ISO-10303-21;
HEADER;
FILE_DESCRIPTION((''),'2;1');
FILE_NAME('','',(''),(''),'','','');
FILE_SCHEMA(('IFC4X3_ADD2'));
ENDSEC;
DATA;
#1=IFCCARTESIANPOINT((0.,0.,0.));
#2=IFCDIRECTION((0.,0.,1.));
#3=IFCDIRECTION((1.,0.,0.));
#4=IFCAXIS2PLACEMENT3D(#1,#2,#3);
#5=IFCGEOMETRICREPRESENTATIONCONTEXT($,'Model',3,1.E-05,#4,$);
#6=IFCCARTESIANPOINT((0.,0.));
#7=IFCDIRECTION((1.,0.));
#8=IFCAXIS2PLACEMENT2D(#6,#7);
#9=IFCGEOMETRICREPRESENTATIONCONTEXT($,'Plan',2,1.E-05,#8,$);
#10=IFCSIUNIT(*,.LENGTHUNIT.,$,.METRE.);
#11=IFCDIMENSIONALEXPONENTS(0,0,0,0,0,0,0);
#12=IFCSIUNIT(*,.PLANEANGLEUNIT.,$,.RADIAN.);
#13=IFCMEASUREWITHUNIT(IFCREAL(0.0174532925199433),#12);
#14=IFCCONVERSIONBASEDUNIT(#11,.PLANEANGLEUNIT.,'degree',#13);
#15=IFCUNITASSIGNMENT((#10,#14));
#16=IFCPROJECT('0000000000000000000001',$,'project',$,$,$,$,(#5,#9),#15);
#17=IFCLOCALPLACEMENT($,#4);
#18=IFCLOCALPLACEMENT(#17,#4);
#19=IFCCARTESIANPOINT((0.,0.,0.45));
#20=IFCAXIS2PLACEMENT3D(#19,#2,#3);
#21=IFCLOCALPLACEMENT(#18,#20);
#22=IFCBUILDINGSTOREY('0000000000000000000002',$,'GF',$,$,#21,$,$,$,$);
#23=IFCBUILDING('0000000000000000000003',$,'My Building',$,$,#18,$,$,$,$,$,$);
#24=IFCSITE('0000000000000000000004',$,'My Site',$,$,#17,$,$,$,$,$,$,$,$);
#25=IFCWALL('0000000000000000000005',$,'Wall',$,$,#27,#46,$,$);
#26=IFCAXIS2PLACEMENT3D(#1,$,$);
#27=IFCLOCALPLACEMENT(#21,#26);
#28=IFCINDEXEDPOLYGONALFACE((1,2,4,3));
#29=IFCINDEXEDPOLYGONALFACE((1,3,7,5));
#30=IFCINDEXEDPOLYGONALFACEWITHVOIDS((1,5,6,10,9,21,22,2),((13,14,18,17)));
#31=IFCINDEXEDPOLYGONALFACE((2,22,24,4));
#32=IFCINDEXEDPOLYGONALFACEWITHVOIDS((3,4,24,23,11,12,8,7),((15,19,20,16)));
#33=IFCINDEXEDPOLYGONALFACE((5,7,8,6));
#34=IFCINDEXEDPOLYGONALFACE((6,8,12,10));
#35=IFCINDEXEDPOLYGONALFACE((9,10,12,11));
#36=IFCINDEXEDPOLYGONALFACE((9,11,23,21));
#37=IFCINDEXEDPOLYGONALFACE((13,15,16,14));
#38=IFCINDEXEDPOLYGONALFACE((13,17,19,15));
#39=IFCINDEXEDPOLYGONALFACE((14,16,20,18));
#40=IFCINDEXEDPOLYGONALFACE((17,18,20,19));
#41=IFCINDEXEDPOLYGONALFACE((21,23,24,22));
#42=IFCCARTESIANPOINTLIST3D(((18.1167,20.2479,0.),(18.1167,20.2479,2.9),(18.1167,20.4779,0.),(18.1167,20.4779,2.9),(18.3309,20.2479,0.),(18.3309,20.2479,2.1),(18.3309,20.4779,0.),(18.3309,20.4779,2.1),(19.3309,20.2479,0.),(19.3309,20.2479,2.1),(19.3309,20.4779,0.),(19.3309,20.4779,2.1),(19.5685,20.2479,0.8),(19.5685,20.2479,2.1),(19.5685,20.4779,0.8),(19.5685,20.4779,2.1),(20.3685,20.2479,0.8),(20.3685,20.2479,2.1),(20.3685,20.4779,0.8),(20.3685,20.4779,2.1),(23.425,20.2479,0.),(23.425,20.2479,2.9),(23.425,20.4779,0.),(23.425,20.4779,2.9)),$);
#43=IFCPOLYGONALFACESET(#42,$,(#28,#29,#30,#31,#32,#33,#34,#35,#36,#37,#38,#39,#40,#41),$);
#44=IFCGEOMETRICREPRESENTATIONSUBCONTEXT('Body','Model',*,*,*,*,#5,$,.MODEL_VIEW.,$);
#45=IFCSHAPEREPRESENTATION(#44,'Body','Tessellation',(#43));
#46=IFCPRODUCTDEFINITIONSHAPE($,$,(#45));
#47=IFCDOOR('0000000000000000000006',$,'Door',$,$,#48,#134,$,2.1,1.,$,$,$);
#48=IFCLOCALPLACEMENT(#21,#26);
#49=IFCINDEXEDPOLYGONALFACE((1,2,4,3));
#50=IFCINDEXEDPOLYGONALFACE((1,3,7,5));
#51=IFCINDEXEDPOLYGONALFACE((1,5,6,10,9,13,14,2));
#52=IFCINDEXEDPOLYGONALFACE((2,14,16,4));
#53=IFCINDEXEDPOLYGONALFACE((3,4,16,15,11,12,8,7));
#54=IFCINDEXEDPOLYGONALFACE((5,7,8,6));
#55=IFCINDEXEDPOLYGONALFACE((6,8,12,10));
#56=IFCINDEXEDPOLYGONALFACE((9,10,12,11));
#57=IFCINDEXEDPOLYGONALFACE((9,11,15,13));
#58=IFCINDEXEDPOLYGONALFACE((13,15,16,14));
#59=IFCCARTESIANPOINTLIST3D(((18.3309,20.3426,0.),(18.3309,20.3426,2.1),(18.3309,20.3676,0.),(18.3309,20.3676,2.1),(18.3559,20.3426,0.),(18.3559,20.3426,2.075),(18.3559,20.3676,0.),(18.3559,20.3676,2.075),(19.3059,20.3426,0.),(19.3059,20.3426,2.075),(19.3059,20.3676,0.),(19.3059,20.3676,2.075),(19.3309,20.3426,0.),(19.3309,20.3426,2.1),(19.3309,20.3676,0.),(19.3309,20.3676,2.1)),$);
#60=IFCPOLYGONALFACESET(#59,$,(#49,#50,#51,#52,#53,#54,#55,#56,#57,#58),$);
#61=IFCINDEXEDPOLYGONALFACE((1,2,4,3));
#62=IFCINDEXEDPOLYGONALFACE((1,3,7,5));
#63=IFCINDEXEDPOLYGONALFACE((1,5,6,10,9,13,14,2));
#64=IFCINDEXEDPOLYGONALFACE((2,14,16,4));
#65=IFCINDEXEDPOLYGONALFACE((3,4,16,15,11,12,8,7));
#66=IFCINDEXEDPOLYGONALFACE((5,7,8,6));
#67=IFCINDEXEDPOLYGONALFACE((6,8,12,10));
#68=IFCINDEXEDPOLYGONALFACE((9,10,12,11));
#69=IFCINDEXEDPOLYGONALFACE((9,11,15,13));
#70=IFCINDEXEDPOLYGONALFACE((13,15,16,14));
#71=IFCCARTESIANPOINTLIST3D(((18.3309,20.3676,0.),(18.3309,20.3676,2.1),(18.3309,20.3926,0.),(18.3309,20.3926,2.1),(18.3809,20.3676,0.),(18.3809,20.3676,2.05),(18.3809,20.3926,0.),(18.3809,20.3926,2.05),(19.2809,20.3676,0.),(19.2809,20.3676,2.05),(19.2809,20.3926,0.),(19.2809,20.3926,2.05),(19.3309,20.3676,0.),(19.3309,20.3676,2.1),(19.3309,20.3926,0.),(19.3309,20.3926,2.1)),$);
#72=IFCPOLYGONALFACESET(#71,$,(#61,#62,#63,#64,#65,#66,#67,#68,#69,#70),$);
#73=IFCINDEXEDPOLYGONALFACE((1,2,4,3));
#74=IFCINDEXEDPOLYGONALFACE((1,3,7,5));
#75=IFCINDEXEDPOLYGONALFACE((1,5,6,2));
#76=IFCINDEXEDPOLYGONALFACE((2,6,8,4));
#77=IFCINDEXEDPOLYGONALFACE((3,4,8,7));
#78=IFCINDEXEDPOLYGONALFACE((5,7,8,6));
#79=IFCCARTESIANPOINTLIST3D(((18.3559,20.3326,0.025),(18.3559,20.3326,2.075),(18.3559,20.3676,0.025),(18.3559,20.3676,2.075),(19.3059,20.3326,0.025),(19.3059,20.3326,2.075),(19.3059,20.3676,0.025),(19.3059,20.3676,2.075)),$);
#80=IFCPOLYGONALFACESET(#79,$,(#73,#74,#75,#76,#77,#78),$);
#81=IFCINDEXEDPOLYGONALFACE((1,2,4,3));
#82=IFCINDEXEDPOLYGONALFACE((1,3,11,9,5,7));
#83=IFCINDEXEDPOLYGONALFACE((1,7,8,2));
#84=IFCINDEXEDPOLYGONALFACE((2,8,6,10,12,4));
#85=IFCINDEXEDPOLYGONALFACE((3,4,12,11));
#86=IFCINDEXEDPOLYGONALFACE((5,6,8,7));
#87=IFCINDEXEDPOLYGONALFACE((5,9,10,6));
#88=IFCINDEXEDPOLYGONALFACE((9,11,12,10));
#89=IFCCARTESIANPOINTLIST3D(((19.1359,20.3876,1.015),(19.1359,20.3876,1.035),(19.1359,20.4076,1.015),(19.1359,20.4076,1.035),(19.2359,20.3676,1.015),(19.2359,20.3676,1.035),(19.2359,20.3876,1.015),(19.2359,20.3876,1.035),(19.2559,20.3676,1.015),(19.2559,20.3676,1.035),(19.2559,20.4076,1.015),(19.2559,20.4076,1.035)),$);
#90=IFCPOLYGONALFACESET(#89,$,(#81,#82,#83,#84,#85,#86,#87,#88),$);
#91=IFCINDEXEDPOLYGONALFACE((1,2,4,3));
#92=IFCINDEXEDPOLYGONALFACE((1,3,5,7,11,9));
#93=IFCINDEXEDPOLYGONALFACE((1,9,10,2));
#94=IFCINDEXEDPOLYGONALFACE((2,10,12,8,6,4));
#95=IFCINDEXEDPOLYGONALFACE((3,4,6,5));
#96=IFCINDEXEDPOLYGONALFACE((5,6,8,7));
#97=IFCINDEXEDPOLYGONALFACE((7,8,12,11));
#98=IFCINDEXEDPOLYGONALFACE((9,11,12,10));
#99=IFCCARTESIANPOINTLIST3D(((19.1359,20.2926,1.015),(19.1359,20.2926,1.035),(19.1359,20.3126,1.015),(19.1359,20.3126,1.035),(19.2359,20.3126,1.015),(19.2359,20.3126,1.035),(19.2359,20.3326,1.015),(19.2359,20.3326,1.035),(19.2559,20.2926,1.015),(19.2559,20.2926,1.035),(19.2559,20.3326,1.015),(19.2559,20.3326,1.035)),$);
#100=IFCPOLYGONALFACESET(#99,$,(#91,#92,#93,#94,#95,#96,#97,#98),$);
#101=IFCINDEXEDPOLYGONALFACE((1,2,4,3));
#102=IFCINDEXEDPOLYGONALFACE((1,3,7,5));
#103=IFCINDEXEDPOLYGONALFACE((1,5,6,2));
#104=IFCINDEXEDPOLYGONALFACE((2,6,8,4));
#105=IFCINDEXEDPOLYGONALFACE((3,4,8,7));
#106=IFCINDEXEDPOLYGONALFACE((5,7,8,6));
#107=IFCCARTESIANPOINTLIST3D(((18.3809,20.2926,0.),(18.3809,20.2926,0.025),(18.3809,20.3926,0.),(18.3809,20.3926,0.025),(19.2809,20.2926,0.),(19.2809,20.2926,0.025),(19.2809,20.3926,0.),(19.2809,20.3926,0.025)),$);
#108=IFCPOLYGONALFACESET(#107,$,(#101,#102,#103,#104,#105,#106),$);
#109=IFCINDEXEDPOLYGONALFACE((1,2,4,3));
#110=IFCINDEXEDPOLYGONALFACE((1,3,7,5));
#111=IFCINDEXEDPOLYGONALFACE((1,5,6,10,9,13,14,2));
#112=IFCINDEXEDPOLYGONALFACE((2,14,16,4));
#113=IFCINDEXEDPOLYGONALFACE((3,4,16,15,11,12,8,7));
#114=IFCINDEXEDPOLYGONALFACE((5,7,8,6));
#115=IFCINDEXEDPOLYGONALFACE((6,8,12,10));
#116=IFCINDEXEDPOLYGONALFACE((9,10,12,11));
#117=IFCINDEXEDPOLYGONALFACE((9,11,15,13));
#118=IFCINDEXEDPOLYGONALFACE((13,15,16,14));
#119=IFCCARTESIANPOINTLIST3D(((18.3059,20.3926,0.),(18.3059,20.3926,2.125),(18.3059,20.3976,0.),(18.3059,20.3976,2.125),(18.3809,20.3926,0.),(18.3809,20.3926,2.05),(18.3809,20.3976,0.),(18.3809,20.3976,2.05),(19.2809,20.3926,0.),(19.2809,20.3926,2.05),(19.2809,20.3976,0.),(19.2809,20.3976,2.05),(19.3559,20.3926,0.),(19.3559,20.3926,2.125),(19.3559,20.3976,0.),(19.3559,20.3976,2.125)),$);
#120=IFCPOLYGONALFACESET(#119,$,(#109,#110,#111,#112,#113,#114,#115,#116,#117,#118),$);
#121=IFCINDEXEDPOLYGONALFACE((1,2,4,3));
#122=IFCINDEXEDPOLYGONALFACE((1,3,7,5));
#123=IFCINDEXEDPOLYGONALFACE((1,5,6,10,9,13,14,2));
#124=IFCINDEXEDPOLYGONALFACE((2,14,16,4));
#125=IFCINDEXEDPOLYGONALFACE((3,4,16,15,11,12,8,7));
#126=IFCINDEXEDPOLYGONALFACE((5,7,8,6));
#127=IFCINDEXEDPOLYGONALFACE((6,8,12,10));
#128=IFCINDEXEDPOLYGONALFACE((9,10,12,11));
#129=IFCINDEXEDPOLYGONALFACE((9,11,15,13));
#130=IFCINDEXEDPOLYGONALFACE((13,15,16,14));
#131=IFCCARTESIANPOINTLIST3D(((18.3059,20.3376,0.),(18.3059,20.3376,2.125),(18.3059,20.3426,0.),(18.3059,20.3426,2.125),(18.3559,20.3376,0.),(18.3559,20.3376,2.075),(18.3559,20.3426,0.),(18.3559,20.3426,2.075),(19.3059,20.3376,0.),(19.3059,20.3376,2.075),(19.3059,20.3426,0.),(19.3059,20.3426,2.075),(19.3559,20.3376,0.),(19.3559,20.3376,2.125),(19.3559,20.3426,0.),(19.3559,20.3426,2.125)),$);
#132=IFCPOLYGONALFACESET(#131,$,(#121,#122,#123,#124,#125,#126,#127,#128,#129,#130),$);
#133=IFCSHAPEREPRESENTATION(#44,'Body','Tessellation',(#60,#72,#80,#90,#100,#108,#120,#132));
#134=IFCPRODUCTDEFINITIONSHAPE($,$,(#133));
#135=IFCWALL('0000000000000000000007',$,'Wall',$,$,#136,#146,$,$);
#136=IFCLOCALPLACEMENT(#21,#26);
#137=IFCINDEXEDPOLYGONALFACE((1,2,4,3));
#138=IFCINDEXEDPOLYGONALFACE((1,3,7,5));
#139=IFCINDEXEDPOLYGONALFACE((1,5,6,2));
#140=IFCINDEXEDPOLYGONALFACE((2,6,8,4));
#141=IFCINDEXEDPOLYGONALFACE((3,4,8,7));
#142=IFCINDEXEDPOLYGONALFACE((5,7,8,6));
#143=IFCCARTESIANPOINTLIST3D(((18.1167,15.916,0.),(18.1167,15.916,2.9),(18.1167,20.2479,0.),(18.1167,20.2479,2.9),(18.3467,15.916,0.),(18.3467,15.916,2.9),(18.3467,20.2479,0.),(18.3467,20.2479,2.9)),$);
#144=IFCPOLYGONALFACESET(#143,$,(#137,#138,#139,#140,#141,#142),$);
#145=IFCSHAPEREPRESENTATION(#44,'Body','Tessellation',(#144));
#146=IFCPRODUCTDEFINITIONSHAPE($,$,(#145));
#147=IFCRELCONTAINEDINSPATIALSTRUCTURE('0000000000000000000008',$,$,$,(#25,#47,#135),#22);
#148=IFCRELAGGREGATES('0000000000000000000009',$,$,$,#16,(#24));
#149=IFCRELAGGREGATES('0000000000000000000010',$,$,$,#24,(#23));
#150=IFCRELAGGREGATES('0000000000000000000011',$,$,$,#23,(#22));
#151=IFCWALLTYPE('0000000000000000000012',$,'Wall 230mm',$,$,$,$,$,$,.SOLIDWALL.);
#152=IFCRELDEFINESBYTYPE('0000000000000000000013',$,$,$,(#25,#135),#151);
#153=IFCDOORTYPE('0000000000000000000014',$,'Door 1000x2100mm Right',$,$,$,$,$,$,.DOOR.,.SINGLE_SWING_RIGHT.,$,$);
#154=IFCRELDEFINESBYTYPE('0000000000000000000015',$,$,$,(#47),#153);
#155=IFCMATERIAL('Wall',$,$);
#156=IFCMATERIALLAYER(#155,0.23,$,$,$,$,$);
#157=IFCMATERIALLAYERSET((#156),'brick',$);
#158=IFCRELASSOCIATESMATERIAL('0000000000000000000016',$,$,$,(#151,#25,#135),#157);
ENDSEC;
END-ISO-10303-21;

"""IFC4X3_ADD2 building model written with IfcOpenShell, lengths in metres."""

from ifc_helpers import new_model, entity, si_unit, converted_unit, frame, origin_with_axes, origin_2d_with_axis, place, context, subcontext, project, spatial, line, indexed_curve, outline, extrude, shape, source, transform, mapped, material, layer, layer_set, layer_usage, type_object, type_shapes, element, fill, save


model = new_model("IFC4X3_ADD2")

# Units and contexts
model_context = context("Model", 3, precision=1e-05, world=origin_with_axes())
plan_context = context("Plan", 2, precision=1e-05, world=origin_2d_with_axis())
body_context_1 = subcontext(model_context, "Body", "Model", "MODEL_VIEW")
body_context_2 = subcontext(plan_context, "Body", "Plan", "PLAN_VIEW")
ifc_project = project(units=[si_unit("LENGTHUNIT", "METRE"), converted_unit("PLANEANGLEUNIT", "degree", entity("IfcReal", 0.0174532925199433), si_unit("PLANEANGLEUNIT", "RADIAN"), dimensions=[0, 0, 0, 0, 0, 0, 0])], contexts=[model_context, plan_context])

# Site, building, storey
site_placement = place(None, origin_with_axes())
site = spatial("IfcSite", under=ifc_project, at=site_placement, Name="My Site")
building_placement = place(site_placement, origin_with_axes())
building = spatial("IfcBuilding", under=site, at=building_placement, Name="My Building")
storey_placement = place(building_placement, frame((0.0, 0.0, 0.45), z_axis=(0.0, 0.0, 1.0), x_axis=(1.0, 0.0, 0.0)))
storey = spatial("IfcBuildingStorey", under=building, at=storey_placement, Name="GF")

# Shared definitions
ifc_material_1 = material(Name="Wall")
ifc_layer = layer(ifc_material_1, 0.23)
ifc_layer_set = layer_set([ifc_layer], Name="brick")
wall_type = type_object("IfcWallType", Name="Wall 230mm", PredefinedType="SOLIDWALL", material=ifc_layer_set)

# Shared definitions
shared_shape_1 = source(origin_with_axes(), body_context_1, "Body", "SweptSolid", [
    extrude(outline(indexed_curve([(0.0, 0.0), (0.8, 0.0), (0.8, 1.3), (0.0, 1.3)], segments=[line(1, 2, 3, 4, 1)])), frame((-0.4, -0.6, 0.0), z_axis=(0.0, -1.0, 0.0), x_axis=(1.0, 0.0, 0.0)), (0.0, 0.0, -1.0), 1.2),
])

# Shared definitions
shared_shape_2 = source(origin_with_axes(), body_context_1, "Body", "SweptSolid", [
    extrude(outline(indexed_curve([(0.0, 0.0), (1.0, 0.0), (1.0, 2.1), (0.0, 2.1)], segments=[line(1, 2, 3, 4, 1)])), frame((0.0, -0.6, 0.0), z_axis=(0.0, -1.0, 0.0), x_axis=(1.0, 0.0, 0.0)), (0.0, 0.0, -1.0), 1.2),
])
door_type_1 = type_object("IfcDoorType", Name="Door 1000x2100mm Right", OperationType="SINGLE_SWING_RIGHT", PredefinedType="DOOR")
shared_shape_3 = source(origin_with_axes(), body_context_1, "Body", "SweptSolid", [
    extrude(outline(indexed_curve([(0.0, 0.0), (0.0, 2.1), (1.0, 2.1), (1.0, 0.0), (0.975, 0.0), (0.975, 2.075), (0.025, 2.075), (0.025, 0.0)], segments=[line(1, 2, 3, 4, 5, 6, 7, 8, 1)])), frame((0.0, 0.025, 0.0), z_axis=(0.0, -1.0, 0.0), x_axis=(1.0, 0.0, 0.0)), (0.0, 0.0, -1.0), 0.025),
    extrude(outline(indexed_curve([(0.0, 0.0), (0.0, 2.1), (1.0, 2.1), (1.0, 0.0), (0.95, 0.0), (0.95, 2.05), (0.05, 2.05), (0.05, 0.0)], segments=[line(1, 2, 3, 4, 5, 6, 7, 8, 1)])), frame((0.0, 0.0, 0.0), z_axis=(0.0, -1.0, 0.0), x_axis=(1.0, 0.0, 0.0)), (0.0, 0.0, -1.0), 0.025),
    extrude(outline(indexed_curve([(0.0, 0.0), (0.95, 0.0), (0.95, 0.035), (0.0, 0.035)], segments=[line(1, 2, 3, 4, 1)])), frame((0.025, 0.025, 0.025), z_axis=(0.0, 0.0, 1.0), x_axis=(1.0, 0.0, 0.0)), (0.0, 0.0, 1.0), 2.05),
    extrude(outline(indexed_curve([(0.0, 0.0), (0.0, -0.04), (0.12, -0.04), (0.12, -0.02), (0.02, -0.02), (0.02, 0.0)], segments=[line(1, 2, 3, 4, 5, 6, 1)])), frame((0.075, 0.025, 1.015), z_axis=(0.0, 0.0, 1.0), x_axis=(1.0, 0.0, 0.0)), (0.0, 0.0, 1.0), 0.02),
    extrude(outline(indexed_curve([(0.0, 0.0), (0.0, 0.04), (0.12, 0.04), (0.12, 0.02), (0.02, 0.02), (0.02, 0.0)], segments=[line(1, 2, 3, 4, 5, 6, 1)])), frame((0.075, 0.06, 1.015), z_axis=(0.0, 0.0, 1.0), x_axis=(1.0, 0.0, 0.0)), (0.0, 0.0, 1.0), 0.02),
    extrude(outline(indexed_curve([(0.0, 0.0), (0.9, 0.0), (0.9, 0.1), (0.0, 0.1)], segments=[line(1, 2, 3, 4, 1)])), frame((0.05, 0.0, 0.0), z_axis=(0.0, 0.0, 1.0), x_axis=(1.0, 0.0, 0.0)), (0.0, 0.0, 1.0), 0.025),
    extrude(outline(indexed_curve([(0.0, 0.0), (0.0, 2.125), (1.05, 2.125), (1.05, 0.0), (0.975, 0.0), (0.975, 2.05), (0.075, 2.05), (0.075, 0.0)], segments=[line(1, 2, 3, 4, 5, 6, 7, 8, 1)])), frame((-0.025, -0.005, 0.0), z_axis=(0.0, -1.0, 0.0), x_axis=(1.0, 0.0, 0.0)), (0.0, 0.0, -1.0), 0.005),
    extrude(outline(indexed_curve([(0.0, 0.0), (0.0, 2.125), (1.05, 2.125), (1.05, 0.0), (1.0, 0.0), (1.0, 2.075), (0.05, 2.075), (0.05, 0.0)], segments=[line(1, 2, 3, 4, 5, 6, 7, 8, 1)])), frame((-0.025, 0.05, 0.0), z_axis=(0.0, -1.0, 0.0), x_axis=(1.0, 0.0, 0.0)), (0.0, 0.0, -1.0), 0.005),
])
shared_shape_4 = source(origin_with_axes(), body_context_2, "Body", "Curve2D", [
    entity("IfcIndexedPolyCurve", entity("IfcCartesianPointList2D", [[0.0, 0.0], [0.0, 0.05], [0.025, 0.05], [0.025, 0.025], [0.05, 0.025], [0.05, 0.0]]), [entity("IfcLineIndex", [1, 2, 3, 4, 5, 6, 1])]),
    entity("IfcIndexedPolyCurve", entity("IfcCartesianPointList2D", [[1.0, 0.0], [1.0, 0.05], [0.975, 0.05], [0.975, 0.025], [0.95, 0.025], [0.95, 0.0]]), [entity("IfcLineIndex", [1, 2, 3, 4, 5, 6, 1])]),
    entity("IfcTrimmedCurve", entity("IfcEllipse", entity("IfcAxis2Placement2D", entity("IfcCartesianPoint", [0.94, 0.05]), entity("IfcDirection", [1.0, 0.0])), 0.915, 0.95), [entity("IfcCartesianPoint", [0.94, 1.0])], [entity("IfcCartesianPoint", [0.025, 0.05])], True, "CARTESIAN"),
    entity("IfcIndexedPolyCurve", entity("IfcCartesianPointList2D", [[0.975, 0.05], [0.94, 0.05], [0.94, 1.0], [0.975, 1.0]]), [entity("IfcLineIndex", [1, 2, 3, 4, 1])]),
])
type_shapes(door_type_1, [shared_shape_3, shared_shape_4])

# Wall, openings, door
ifc_layer_usage_1 = layer_usage(ifc_layer_set, "AXIS2", "POSITIVE", 0.0)
wall_1_placement = place(storey_placement, frame((18.1167, 20.2479, 0.0), z_axis=(0.0, 0.0, 1.0), x_axis=(1.0, 0.0, 0.0)))
wall_1 = element("IfcWall", 1, at=wall_1_placement, inside=storey, type_object=wall_type, material=ifc_layer_usage_1, Name="Wall", context=body_context_1, shape_type="SweptSolid", body=[
    extrude(outline(indexed_curve([(0.0, 0.0), (0.0, 0.23), (5.3083, 0.23), (5.3083, 0.0), (0.0, 0.0)], self_intersect=False)), origin_with_axes(), (0.0, 0.0, 1.0), 2.9),
])
opening_1_placement = place(wall_1_placement, frame((1.8518, 0.1486, 0.8), z_axis=(0.0, 0.0, 1.0), x_axis=(-1.0, 0.0, 0.0)))
element("IfcOpeningElement", 2, at=opening_1_placement, cuts=wall_1, PredefinedType="OPENING", context=body_context_1, shape_type="MappedRepresentation", body=[
    mapped(shared_shape_1, transform((0.0, 0.0, 0.0), x_axis=(1.0, 0.0, 0.0), y_axis=(0.0, 1.0, 0.0), z_axis=(0.0, 0.0, 1.0), scale=1.0)),
])
opening_2_placement = place(wall_1_placement, frame((1.2142, 0.1447, 0.0), z_axis=(0.0, 0.0, 1.0), x_axis=(-1.0, 0.0, 0.0)))
opening_2 = element("IfcOpeningElement", 3, at=opening_2_placement, cuts=wall_1, PredefinedType="OPENING", context=body_context_1, shape_type="MappedRepresentation", body=[
    mapped(shared_shape_2, transform((0.0, 0.0, 0.0), x_axis=(1.0, 0.0, 0.0), y_axis=(0.0, 1.0, 0.0), z_axis=(0.0, 0.0, 1.0), scale=1.0)),
])
door_1_placement = place(opening_2_placement, origin_with_axes())
door_1 = element("IfcDoor", 4, at=door_1_placement, inside=storey, type_object=door_type_1, Name="Door", OverallHeight=2.1, OverallWidth=1.0, shapes=[
    shape(body_context_1, "Body", "MappedRepresentation", [mapped(shared_shape_3, transform((0.0, 0.0, 0.0), x_axis=(1.0, 0.0, 0.0), y_axis=(0.0, 1.0, 0.0), z_axis=(0.0, 0.0, 1.0), scale=1.0))]),
    shape(body_context_2, "Body", "MappedRepresentation", [mapped(shared_shape_4, transform((0.0, 0.0, 0.0), x_axis=(1.0, 0.0, 0.0), y_axis=(0.0, 1.0, 0.0), z_axis=(0.0, 0.0, 1.0), scale=1.0))]),
])
fill(opening_2, door_1)

# Wall
ifc_layer_usage_2 = layer_usage(ifc_layer_set, "AXIS2", "POSITIVE", 0.0)
wall_2_placement = place(storey_placement, frame((18.3467, 15.916, 0.0), z_axis=(0.0, 0.0, 1.0), x_axis=(0.0, 1.0, 0.0)))
element("IfcWall", 5, at=wall_2_placement, inside=storey, type_object=wall_type, material=ifc_layer_usage_2, Name="Wall", context=body_context_1, shape_type="SweptSolid", body=[
    extrude(outline(indexed_curve([(0.0, 0.0), (0.0, 0.23), (4.3319, 0.23), (4.3319, 0.0), (0.0, 0.0)], self_intersect=False)), origin_with_axes(), (0.0, 0.0, 1.0), 2.9),
])

save(model, "model.ifc")
